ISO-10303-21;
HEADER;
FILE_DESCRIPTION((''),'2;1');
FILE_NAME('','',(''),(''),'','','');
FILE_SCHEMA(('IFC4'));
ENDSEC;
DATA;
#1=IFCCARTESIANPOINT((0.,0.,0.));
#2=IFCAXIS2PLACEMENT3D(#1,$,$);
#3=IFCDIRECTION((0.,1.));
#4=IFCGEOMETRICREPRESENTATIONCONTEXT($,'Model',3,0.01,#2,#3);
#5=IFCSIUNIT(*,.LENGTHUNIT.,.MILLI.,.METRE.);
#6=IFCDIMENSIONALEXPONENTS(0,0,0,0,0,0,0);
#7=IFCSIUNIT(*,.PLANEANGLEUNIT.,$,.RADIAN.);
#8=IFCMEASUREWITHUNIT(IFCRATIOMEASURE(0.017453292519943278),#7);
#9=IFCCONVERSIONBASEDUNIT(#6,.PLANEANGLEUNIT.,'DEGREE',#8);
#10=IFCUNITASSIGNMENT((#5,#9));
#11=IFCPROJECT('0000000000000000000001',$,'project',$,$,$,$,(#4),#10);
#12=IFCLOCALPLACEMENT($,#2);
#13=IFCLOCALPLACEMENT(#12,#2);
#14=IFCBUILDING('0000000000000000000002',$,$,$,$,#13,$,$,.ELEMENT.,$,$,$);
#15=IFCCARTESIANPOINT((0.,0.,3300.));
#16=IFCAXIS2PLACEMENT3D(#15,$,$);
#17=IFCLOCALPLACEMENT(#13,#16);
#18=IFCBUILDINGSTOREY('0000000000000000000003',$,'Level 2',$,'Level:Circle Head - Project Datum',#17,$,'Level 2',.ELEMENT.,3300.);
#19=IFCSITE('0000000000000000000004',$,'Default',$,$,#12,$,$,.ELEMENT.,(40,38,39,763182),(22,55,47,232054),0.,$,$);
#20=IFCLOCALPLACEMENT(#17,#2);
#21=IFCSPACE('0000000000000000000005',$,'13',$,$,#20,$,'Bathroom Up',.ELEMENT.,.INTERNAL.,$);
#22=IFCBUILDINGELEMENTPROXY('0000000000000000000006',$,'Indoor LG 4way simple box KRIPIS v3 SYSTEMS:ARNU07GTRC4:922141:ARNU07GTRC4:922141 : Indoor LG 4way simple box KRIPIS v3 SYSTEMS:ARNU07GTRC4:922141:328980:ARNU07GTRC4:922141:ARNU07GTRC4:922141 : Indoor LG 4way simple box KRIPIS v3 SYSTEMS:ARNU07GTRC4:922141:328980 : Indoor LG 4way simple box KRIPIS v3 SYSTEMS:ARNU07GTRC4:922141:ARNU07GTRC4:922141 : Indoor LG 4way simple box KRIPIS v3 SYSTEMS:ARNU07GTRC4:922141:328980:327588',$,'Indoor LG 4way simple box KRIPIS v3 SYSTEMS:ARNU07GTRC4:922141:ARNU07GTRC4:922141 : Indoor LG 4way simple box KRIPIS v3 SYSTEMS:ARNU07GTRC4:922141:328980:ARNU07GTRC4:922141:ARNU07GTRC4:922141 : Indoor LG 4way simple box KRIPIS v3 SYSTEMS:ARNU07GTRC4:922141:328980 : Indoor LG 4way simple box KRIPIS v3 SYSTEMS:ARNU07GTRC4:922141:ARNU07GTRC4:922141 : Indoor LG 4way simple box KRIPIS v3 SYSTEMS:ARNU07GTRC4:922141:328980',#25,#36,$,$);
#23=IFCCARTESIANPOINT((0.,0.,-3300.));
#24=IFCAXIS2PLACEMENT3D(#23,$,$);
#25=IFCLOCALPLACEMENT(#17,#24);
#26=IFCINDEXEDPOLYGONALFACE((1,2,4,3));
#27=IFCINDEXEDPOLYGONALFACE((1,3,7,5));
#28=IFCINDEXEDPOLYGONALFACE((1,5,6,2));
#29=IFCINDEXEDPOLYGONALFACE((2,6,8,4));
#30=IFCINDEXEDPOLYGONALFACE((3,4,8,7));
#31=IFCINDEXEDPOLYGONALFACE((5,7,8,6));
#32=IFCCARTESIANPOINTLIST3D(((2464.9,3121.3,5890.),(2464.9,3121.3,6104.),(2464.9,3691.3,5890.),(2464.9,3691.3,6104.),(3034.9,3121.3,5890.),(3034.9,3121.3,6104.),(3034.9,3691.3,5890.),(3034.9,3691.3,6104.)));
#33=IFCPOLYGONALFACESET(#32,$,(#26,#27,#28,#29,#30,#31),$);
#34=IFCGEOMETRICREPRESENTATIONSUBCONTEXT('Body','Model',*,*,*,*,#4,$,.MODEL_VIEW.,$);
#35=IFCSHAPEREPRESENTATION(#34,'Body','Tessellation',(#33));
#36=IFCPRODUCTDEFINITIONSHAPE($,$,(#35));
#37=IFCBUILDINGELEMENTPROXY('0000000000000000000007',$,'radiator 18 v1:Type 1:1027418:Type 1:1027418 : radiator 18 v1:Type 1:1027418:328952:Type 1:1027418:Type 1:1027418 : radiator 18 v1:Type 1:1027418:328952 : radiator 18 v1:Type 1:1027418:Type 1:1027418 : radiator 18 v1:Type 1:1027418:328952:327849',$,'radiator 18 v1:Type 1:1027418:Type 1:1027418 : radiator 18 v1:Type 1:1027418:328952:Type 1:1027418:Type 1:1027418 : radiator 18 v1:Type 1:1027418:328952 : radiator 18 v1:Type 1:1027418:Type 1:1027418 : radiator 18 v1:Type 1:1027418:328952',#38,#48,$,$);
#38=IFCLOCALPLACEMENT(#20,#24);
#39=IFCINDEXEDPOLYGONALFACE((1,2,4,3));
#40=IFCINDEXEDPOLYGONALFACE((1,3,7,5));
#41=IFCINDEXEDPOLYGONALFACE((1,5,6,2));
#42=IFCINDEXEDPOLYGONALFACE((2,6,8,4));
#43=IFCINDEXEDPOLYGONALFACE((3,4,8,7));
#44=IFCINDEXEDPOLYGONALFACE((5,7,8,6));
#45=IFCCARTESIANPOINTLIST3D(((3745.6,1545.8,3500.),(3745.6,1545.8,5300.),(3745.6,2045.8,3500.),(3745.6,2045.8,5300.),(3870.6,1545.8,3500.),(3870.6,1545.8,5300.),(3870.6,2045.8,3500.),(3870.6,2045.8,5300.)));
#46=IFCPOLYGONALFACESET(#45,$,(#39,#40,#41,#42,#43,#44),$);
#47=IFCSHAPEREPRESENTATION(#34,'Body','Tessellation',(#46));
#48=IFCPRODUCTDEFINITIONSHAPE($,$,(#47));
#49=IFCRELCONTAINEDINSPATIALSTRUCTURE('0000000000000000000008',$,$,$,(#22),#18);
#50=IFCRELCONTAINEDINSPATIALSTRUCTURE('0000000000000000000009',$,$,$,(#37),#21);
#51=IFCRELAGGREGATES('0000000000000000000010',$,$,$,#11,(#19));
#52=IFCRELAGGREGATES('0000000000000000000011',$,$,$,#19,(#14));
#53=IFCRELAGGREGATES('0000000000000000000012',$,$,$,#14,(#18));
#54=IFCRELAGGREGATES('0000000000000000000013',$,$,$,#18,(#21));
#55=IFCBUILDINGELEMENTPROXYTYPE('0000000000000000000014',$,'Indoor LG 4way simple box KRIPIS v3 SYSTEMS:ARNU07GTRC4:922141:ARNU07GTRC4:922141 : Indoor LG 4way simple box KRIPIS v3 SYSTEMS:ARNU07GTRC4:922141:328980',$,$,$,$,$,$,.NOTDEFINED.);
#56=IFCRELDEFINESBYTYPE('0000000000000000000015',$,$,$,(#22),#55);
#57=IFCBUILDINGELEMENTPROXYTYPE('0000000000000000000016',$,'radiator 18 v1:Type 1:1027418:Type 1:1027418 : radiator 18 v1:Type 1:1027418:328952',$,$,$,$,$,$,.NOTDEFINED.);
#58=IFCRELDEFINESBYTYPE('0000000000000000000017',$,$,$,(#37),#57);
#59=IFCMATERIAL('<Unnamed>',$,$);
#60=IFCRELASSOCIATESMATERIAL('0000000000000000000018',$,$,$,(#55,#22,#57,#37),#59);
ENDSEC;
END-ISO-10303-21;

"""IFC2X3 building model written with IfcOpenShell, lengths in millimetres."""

from ifc_helpers import new_model, entity, si_unit, converted_unit, direction, frame, origin, origin_2d_with_axis, place, context, subcontext, project, spatial, rectangle, extrude, source, transform, mapped, material, type_object, type_shapes, element, save


model = new_model("IFC2X3")

# Units and contexts
model_context = context("Model", 3, precision=0.01, world=origin(), true_north=direction((0.0, 1.0)))
body_context = subcontext(model_context, "Body", "Model", "MODEL_VIEW")
ifc_project = project(units=[si_unit("LENGTHUNIT", "METRE", prefix="MILLI"), converted_unit("PLANEANGLEUNIT", "DEGREE", entity("IfcRatioMeasure", 0.017453292519943278), si_unit("PLANEANGLEUNIT", "RADIAN"), dimensions=[0, 0, 0, 0, 0, 0, 0])], contexts=[model_context])

# Site, building, storey
site_placement = place(None, origin())
site = spatial("IfcSite", under=ifc_project, at=site_placement, Name="Default", CompositionType="ELEMENT", RefLatitude=(40, 38, 39, 763182), RefLongitude=(22, 55, 47, 232054), RefElevation=0.0)
building_placement = place(site_placement, origin())
building = spatial("IfcBuilding", under=site, at=building_placement, CompositionType="ELEMENT")
storey_placement = place(building_placement, frame((0.0, 0.0, 3300.0)))
storey = spatial("IfcBuildingStorey", under=building, at=storey_placement, Name="Level 2", ObjectType="Level:Circle Head - Project Datum", LongName="Level 2", CompositionType="ELEMENT", Elevation=3300.0)

# Shared definitions
ifc_material_1 = material(Name="<Unnamed>")

# Building element proxy
building_element_proxy_type_1 = type_object("IfcBuildingElementProxyType", Name="Indoor LG 4way simple box KRIPIS v3 SYSTEMS:ARNU07GTRC4:922141:ARNU07GTRC4:922141 : Indoor LG 4way simple box KRIPIS v3 SYSTEMS:ARNU07GTRC4:922141:328980", PredefinedType="NOTDEFINED", material=ifc_material_1)
shared_shape_1 = source(origin(), body_context, "Body", "SweptSolid", [
    extrude(rectangle(XDim=570.0, YDim=570.0, at=origin_2d_with_axis()), frame((2749.9, 3406.3, 5890.0)), (0.0, 0.0, 1.0), 214.0),
])
type_shapes(building_element_proxy_type_1, [shared_shape_1])
proxy_1_placement = place(storey_placement, frame((0.0, 0.0, -3300.0)))
element("IfcBuildingElementProxy", 1, at=proxy_1_placement, inside=storey, type_object=building_element_proxy_type_1, material=ifc_material_1, Name="Indoor LG 4way simple box KRIPIS v3 SYSTEMS:ARNU07GTRC4:922141:ARNU07GTRC4:922141 : Indoor LG 4way simple box KRIPIS v3 SYSTEMS:ARNU07GTRC4:922141:328980:ARNU07GTRC4:922141:ARNU07GTRC4:922141 : Indoor LG 4way simple box KRIPIS v3 SYSTEMS:ARNU07GTRC4:922141:328980 : Indoor LG 4way simple box KRIPIS v3 SYSTEMS:ARNU07GTRC4:922141:ARNU07GTRC4:922141 : Indoor LG 4way simple box KRIPIS v3 SYSTEMS:ARNU07GTRC4:922141:328980:327588", ObjectType="Indoor LG 4way simple box KRIPIS v3 SYSTEMS:ARNU07GTRC4:922141:ARNU07GTRC4:922141 : Indoor LG 4way simple box KRIPIS v3 SYSTEMS:ARNU07GTRC4:922141:328980:ARNU07GTRC4:922141:ARNU07GTRC4:922141 : Indoor LG 4way simple box KRIPIS v3 SYSTEMS:ARNU07GTRC4:922141:328980 : Indoor LG 4way simple box KRIPIS v3 SYSTEMS:ARNU07GTRC4:922141:ARNU07GTRC4:922141 : Indoor LG 4way simple box KRIPIS v3 SYSTEMS:ARNU07GTRC4:922141:328980", context=body_context, shape_type="MappedRepresentation", body=[
    mapped(shared_shape_1, transform((0.0, 0.0, 0.0), scale=1.0)),
])

# Shared definitions
space_placement = place(storey_placement, origin())
space = spatial("IfcSpace", under=storey, at=space_placement, Name="13", LongName="Bathroom Up", CompositionType="ELEMENT", InteriorOrExteriorSpace="INTERNAL")

# Building element proxy
building_element_proxy_type_2 = type_object("IfcBuildingElementProxyType", Name="radiator 18 v1:Type 1:1027418:Type 1:1027418 : radiator 18 v1:Type 1:1027418:328952", PredefinedType="NOTDEFINED", material=ifc_material_1)
shared_shape_2 = source(origin(), body_context, "Body", "SweptSolid", [
    extrude(rectangle(XDim=500.0, YDim=125.0, at=origin_2d_with_axis()), frame((3808.1, 1795.8, 3500.0), z_axis=(0.0, 0.0, 1.0), x_axis=(0.0, -1.0, 0.0)), (0.0, 0.0, 1.0), 1800.0),
])
type_shapes(building_element_proxy_type_2, [shared_shape_2])
proxy_2_placement = place(space_placement, frame((0.0, 0.0, -3300.0)))
element("IfcBuildingElementProxy", 2, at=proxy_2_placement, inside=space, type_object=building_element_proxy_type_2, material=ifc_material_1, Name="radiator 18 v1:Type 1:1027418:Type 1:1027418 : radiator 18 v1:Type 1:1027418:328952:Type 1:1027418:Type 1:1027418 : radiator 18 v1:Type 1:1027418:328952 : radiator 18 v1:Type 1:1027418:Type 1:1027418 : radiator 18 v1:Type 1:1027418:328952:327849", ObjectType="radiator 18 v1:Type 1:1027418:Type 1:1027418 : radiator 18 v1:Type 1:1027418:328952:Type 1:1027418:Type 1:1027418 : radiator 18 v1:Type 1:1027418:328952 : radiator 18 v1:Type 1:1027418:Type 1:1027418 : radiator 18 v1:Type 1:1027418:328952", context=body_context, shape_type="MappedRepresentation", body=[
    mapped(shared_shape_2, transform((0.0, 0.0, 0.0), scale=1.0)),
])

save(model, "model.ifc")
